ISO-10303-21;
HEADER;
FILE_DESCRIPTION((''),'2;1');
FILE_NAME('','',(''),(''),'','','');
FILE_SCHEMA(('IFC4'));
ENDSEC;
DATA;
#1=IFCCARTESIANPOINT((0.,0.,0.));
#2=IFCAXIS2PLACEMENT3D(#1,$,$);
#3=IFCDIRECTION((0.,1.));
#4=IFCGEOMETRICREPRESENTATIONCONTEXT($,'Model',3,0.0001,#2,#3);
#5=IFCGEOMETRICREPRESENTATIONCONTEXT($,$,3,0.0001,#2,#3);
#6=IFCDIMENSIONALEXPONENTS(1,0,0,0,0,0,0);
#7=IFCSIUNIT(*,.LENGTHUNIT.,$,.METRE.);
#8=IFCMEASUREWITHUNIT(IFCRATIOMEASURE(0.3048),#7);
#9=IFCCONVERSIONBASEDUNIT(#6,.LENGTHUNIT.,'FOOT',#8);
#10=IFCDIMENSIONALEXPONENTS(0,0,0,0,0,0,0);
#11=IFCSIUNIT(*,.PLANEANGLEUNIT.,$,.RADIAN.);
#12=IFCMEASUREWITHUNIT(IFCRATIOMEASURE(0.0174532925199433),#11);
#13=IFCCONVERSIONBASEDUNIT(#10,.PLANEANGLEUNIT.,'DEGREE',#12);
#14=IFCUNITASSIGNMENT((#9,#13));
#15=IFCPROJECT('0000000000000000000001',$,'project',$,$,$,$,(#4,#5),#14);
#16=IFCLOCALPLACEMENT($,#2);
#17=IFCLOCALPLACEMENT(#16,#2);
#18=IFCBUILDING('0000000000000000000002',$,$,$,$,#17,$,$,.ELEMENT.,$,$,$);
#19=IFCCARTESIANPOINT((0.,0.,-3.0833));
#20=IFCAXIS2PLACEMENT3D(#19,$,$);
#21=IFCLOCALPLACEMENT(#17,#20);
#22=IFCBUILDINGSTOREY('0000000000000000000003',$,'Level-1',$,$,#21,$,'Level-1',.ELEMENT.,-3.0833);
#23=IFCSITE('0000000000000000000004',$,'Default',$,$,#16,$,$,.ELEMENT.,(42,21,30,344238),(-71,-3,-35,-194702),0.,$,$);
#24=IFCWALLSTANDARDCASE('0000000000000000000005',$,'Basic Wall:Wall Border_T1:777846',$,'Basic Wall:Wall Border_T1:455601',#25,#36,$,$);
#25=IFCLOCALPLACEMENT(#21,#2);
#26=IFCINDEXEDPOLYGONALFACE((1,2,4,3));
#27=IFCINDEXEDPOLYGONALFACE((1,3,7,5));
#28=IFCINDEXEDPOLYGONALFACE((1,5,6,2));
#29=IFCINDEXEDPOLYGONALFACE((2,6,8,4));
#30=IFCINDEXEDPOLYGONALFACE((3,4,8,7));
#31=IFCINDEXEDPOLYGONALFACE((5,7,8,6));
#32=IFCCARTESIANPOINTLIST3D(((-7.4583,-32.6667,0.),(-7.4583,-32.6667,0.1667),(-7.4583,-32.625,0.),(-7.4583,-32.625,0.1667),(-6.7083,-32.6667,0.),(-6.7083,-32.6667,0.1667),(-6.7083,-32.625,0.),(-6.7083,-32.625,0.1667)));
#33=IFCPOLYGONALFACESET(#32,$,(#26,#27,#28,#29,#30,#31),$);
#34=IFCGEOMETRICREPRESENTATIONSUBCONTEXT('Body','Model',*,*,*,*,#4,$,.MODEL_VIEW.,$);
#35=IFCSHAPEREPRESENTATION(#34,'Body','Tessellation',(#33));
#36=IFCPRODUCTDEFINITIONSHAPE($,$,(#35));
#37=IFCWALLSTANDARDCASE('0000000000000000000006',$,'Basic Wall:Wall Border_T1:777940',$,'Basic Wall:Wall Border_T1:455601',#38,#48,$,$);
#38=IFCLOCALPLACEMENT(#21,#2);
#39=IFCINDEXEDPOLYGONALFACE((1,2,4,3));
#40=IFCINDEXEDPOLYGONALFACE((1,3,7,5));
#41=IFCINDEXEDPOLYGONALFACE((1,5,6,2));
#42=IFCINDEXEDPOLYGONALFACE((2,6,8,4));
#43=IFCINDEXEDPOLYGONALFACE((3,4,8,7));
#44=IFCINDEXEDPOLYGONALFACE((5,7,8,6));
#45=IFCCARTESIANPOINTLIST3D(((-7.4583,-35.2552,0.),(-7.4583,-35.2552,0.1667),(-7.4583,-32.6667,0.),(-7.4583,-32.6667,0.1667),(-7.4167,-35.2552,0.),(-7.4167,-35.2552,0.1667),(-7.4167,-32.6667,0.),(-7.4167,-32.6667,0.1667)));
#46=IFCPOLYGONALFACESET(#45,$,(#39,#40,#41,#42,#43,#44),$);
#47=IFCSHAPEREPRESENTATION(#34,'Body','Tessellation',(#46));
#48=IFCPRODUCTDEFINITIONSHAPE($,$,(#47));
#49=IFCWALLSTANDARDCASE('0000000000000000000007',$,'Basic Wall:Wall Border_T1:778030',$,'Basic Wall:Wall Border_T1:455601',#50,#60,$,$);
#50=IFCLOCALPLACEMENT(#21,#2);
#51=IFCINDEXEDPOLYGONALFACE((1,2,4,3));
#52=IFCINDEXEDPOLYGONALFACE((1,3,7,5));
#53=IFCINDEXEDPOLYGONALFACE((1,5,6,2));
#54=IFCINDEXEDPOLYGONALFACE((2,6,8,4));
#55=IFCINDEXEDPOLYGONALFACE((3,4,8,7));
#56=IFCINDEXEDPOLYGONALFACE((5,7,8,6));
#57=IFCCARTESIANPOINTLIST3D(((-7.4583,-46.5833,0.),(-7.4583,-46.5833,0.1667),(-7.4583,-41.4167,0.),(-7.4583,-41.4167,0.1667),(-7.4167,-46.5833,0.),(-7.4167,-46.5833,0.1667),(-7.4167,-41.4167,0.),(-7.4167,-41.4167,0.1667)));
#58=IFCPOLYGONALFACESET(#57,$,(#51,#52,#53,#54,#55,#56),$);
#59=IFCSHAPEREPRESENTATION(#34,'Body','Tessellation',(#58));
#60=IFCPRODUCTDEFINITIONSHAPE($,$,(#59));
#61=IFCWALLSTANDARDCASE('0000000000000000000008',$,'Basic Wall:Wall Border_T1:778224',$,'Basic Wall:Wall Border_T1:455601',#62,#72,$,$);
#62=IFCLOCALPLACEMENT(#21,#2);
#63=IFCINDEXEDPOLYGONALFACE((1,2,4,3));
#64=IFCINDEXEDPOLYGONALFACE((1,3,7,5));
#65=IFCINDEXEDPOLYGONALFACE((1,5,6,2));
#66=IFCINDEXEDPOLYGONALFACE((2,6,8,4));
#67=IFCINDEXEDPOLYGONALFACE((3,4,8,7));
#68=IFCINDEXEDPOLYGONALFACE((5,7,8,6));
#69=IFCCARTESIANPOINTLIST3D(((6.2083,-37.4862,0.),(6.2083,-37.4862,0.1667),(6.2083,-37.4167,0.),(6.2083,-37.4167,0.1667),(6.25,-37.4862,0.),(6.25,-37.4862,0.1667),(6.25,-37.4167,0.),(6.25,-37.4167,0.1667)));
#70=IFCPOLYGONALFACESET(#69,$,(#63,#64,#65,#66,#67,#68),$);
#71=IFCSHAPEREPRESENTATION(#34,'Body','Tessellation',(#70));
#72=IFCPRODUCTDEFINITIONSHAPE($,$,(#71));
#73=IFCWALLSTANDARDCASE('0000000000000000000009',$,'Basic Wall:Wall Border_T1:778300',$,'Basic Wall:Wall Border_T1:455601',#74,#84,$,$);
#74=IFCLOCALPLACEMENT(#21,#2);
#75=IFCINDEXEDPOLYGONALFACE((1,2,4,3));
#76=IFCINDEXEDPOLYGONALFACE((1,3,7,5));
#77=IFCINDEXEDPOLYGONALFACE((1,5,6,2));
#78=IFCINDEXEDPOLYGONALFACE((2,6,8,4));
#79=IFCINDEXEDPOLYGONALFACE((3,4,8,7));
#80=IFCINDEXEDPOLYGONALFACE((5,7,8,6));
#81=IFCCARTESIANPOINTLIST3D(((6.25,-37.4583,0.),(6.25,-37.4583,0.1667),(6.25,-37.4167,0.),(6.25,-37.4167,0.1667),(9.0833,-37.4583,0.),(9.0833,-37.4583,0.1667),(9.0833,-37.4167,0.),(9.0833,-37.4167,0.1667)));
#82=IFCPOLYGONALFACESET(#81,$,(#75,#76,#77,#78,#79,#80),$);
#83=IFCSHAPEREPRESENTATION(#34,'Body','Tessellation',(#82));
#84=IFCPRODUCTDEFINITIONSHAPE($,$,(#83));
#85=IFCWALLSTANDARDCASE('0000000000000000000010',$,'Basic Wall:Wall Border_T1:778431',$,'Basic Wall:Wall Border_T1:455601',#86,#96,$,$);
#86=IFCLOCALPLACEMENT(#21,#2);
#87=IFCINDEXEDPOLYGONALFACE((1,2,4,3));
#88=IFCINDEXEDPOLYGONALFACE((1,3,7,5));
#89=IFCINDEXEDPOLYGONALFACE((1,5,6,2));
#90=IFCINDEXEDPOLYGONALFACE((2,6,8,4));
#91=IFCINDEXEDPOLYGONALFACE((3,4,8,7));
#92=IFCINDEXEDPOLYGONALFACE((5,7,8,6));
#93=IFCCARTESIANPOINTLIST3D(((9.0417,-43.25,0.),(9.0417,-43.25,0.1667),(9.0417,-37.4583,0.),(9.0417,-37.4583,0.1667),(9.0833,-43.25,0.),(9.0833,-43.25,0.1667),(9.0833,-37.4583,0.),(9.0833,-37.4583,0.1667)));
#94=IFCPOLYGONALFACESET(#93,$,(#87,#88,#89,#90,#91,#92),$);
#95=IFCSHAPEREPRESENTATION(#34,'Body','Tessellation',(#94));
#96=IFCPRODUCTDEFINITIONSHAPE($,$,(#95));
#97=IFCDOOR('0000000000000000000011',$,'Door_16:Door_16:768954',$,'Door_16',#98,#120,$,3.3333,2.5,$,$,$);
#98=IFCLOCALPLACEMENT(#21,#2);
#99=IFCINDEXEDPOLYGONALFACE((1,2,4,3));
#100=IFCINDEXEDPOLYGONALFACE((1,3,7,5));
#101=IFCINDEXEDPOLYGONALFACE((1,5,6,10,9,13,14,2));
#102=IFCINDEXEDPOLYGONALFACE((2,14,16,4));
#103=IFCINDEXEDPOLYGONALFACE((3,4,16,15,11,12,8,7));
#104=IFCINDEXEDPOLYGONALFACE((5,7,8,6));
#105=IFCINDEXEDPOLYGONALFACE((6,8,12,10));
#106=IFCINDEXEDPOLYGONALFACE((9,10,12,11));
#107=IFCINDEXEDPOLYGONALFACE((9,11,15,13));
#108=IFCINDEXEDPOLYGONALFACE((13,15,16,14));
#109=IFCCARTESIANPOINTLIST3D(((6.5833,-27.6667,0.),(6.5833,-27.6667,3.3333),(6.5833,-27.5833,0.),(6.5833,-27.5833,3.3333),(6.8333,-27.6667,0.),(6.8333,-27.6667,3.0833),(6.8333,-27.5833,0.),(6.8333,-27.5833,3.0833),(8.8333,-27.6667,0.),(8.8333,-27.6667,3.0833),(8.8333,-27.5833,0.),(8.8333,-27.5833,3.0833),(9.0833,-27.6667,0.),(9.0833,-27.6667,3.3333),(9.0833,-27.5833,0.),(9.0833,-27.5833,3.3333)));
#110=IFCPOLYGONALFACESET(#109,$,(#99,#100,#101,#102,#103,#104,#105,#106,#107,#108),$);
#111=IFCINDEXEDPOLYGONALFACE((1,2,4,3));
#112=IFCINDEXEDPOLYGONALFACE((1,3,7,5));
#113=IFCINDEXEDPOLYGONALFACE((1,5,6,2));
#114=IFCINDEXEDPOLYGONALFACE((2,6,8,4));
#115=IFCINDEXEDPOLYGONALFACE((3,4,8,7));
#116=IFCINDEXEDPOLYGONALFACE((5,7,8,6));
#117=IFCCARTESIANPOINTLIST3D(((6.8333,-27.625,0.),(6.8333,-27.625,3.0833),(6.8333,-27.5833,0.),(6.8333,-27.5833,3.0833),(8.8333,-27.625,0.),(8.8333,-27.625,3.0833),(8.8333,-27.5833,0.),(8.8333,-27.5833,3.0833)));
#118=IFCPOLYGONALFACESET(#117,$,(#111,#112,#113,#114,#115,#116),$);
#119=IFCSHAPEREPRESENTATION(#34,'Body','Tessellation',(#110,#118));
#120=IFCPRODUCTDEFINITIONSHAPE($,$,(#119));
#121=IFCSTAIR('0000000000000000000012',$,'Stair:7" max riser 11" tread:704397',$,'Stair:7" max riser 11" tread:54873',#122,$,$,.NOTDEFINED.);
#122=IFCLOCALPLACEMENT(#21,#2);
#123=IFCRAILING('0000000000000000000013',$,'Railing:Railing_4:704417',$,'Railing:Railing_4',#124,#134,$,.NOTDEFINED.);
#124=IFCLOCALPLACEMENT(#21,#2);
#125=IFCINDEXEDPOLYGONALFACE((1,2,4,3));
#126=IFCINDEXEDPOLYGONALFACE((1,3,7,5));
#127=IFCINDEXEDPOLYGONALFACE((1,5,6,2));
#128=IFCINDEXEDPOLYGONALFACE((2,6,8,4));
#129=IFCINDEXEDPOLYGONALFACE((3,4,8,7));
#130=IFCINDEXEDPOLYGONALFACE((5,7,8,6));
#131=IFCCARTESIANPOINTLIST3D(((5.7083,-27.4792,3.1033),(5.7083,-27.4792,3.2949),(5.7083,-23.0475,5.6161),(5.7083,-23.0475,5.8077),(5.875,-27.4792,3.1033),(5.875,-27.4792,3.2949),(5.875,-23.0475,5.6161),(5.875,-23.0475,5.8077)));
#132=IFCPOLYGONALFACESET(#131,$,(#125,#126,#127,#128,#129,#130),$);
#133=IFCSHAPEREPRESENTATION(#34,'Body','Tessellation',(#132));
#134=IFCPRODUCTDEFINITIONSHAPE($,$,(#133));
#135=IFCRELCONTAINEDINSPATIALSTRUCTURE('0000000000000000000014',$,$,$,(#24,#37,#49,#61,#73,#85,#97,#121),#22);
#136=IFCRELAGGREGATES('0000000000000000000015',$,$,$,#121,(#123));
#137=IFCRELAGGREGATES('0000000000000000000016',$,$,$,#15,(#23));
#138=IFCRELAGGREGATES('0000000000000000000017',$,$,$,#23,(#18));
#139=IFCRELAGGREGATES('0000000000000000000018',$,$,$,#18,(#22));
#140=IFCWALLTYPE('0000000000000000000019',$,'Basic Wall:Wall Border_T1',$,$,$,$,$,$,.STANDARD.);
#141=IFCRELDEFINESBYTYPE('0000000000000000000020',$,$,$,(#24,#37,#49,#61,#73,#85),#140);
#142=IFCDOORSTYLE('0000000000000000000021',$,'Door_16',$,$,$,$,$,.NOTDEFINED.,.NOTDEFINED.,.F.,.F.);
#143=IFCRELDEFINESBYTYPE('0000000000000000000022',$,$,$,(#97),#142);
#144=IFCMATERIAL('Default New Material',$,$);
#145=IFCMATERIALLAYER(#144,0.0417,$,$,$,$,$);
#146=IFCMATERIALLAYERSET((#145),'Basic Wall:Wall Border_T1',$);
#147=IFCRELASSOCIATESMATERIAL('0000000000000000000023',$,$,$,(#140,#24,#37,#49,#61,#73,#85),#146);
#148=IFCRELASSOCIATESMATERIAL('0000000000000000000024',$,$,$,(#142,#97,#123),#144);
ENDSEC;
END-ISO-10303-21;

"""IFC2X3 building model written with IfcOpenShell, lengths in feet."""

from ifc_helpers import new_model, entity, si_unit, converted_unit, direction, frame, frame_2d, origin, place, context, subcontext, project, spatial, polyline, rectangle, outline, extrude, source, transform, mapped, material, layer, layer_set, layer_usage, type_object, type_shapes, element, aggregate, save


model = new_model("IFC2X3")

# Units and contexts
model_context = context("Model", 3, precision=0.0001, world=origin(), true_north=direction((0.0, 1.0)))
context_of_model = context(None, 3, precision=0.0001, world=origin(), true_north=direction((0.0, 1.0)))
body_context = subcontext(model_context, "Body", "Model", "MODEL_VIEW")
ifc_project = project(units=[converted_unit("LENGTHUNIT", "FOOT", entity("IfcRatioMeasure", 0.3048), si_unit("LENGTHUNIT", "METRE"), dimensions=[1, 0, 0, 0, 0, 0, 0]), converted_unit("PLANEANGLEUNIT", "DEGREE", entity("IfcRatioMeasure", 0.0174532925199433), si_unit("PLANEANGLEUNIT", "RADIAN"), dimensions=[0, 0, 0, 0, 0, 0, 0])], contexts=[model_context, context_of_model])

# Site, building, storey
site_placement = place(None, origin())
site = spatial("IfcSite", under=ifc_project, at=site_placement, Name="Default", CompositionType="ELEMENT", RefLatitude=(42, 21, 30, 344238), RefLongitude=(-71, -3, -35, -194702), RefElevation=0.0)
building_placement = place(site_placement, origin())
building = spatial("IfcBuilding", under=site, at=building_placement, CompositionType="ELEMENT")
storey_placement = place(building_placement, frame((0.0, 0.0, -3.0833)))
storey = spatial("IfcBuildingStorey", under=building, at=storey_placement, Name="Level-1", LongName="Level-1", CompositionType="ELEMENT", Elevation=-3.0833)

# Shared definitions
ifc_material_1 = material(Name="Default New Material")

# Walls
ifc_layer_1 = layer(ifc_material_1, 0.0417)
ifc_layer_set_1 = layer_set([ifc_layer_1], Name="Basic Wall:Wall Border_T1")
wall_type_1 = type_object("IfcWallType", Name="Basic Wall:Wall Border_T1", PredefinedType="STANDARD", material=ifc_layer_set_1)
ifc_layer_usage_1 = layer_usage(ifc_layer_set_1, "AXIS2", "NEGATIVE", 0.0208)
wall_1_placement = place(storey_placement, frame((-6.7083, -32.6458, 0.0), z_axis=(0.0, 0.0, 1.0), x_axis=(-1.0, 0.0, 0.0)))
element("IfcWallStandardCase", 1, at=wall_1_placement, inside=storey, type_object=wall_type_1, material=ifc_layer_usage_1, Name="Basic Wall:Wall Border_T1:777846", ObjectType="Basic Wall:Wall Border_T1:455601", context=body_context, shape_type="SweptSolid", body=[
    extrude(rectangle(XDim=0.75, YDim=0.0417, at=frame_2d((0.375, 0.0), x_axis=(-1.0, 0.0))), origin(), (0.0, 0.0, 1.0), 0.1667),
])
ifc_layer_usage_2 = layer_usage(ifc_layer_set_1, "AXIS2", "NEGATIVE", 0.0208)
wall_2_placement = place(storey_placement, frame((-7.4375, -32.6667, 0.0), z_axis=(0.0, 0.0, 1.0), x_axis=(0.0, -1.0, 0.0)))
element("IfcWallStandardCase", 2, at=wall_2_placement, inside=storey, type_object=wall_type_1, material=ifc_layer_usage_2, Name="Basic Wall:Wall Border_T1:777940", ObjectType="Basic Wall:Wall Border_T1:455601", context=body_context, shape_type="SweptSolid", body=[
    extrude(rectangle(XDim=2.5886, YDim=0.0417, at=frame_2d((1.2943, 0.0), x_axis=(-1.0, 0.0))), origin(), (0.0, 0.0, 1.0), 0.1667),
])
ifc_layer_usage_3 = layer_usage(ifc_layer_set_1, "AXIS2", "NEGATIVE", 0.0208)
wall_3_placement = place(storey_placement, frame((-7.4375, -41.4167, 0.0), z_axis=(0.0, 0.0, 1.0), x_axis=(0.0, -1.0, 0.0)))
element("IfcWallStandardCase", 3, at=wall_3_placement, inside=storey, type_object=wall_type_1, material=ifc_layer_usage_3, Name="Basic Wall:Wall Border_T1:778030", ObjectType="Basic Wall:Wall Border_T1:455601", context=body_context, shape_type="SweptSolid", body=[
    extrude(rectangle(XDim=5.1667, YDim=0.0417, at=frame_2d((2.5833, 0.0), x_axis=(-1.0, 0.0))), origin(), (0.0, 0.0, 1.0), 0.1667),
])
ifc_layer_usage_4 = layer_usage(ifc_layer_set_1, "AXIS2", "POSITIVE", -0.0208)
wall_4_placement = place(storey_placement, frame((6.2292, -37.4862, 0.0), z_axis=(0.0, 0.0, 1.0), x_axis=(0.0, 1.0, 0.0)))
element("IfcWallStandardCase", 4, at=wall_4_placement, inside=storey, type_object=wall_type_1, material=ifc_layer_usage_4, Name="Basic Wall:Wall Border_T1:778224", ObjectType="Basic Wall:Wall Border_T1:455601", context=body_context, shape_type="SweptSolid", body=[
    extrude(rectangle(XDim=0.0696, YDim=0.0417, at=frame_2d((0.0348, 0.0), x_axis=(-1.0, 0.0))), origin(), (0.0, 0.0, 1.0), 0.1667),
])
ifc_layer_usage_5 = layer_usage(ifc_layer_set_1, "AXIS2", "POSITIVE", -0.0208)
wall_5_placement = place(storey_placement, frame((6.25, -37.4375, 0.0)))
element("IfcWallStandardCase", 5, at=wall_5_placement, inside=storey, type_object=wall_type_1, material=ifc_layer_usage_5, Name="Basic Wall:Wall Border_T1:778300", ObjectType="Basic Wall:Wall Border_T1:455601", context=body_context, shape_type="SweptSolid", body=[
    extrude(rectangle(XDim=2.8333, YDim=0.0417, at=frame_2d((1.4167, 0.0), x_axis=(-1.0, 0.0))), origin(), (0.0, 0.0, 1.0), 0.1667),
])
ifc_layer_usage_6 = layer_usage(ifc_layer_set_1, "AXIS2", "POSITIVE", -0.0208)
wall_6_placement = place(storey_placement, frame((9.0625, -37.4583, 0.0), z_axis=(0.0, 0.0, 1.0), x_axis=(0.0, -1.0, 0.0)))
element("IfcWallStandardCase", 6, at=wall_6_placement, inside=storey, type_object=wall_type_1, material=ifc_layer_usage_6, Name="Basic Wall:Wall Border_T1:778431", ObjectType="Basic Wall:Wall Border_T1:455601", context=body_context, shape_type="SweptSolid", body=[
    extrude(rectangle(XDim=5.7917, YDim=0.0417, at=frame_2d((2.8958, 0.0), x_axis=(-1.0, 0.0))), origin(), (0.0, 0.0, 1.0), 0.1667),
])

# Door
door_style_1 = type_object("IfcDoorStyle", Name="Door_16", ConstructionType="NOTDEFINED", OperationType="NOTDEFINED", ParameterTakesPrecedence=False, Sizeable=False, material=ifc_material_1)
shared_shape_1 = source(origin(), body_context, "Body", "SweptSolid", [
    extrude(outline(polyline([(-1.4792, 1.0), (1.6042, 1.0), (1.6042, 1.25), (-1.7292, 1.25), (-1.7292, -1.25), (1.6042, -1.25), (1.6042, -1.0), (-1.4792, -1.0), (-1.4792, 1.0)])), frame((7.8333, -27.6667, -1.4792), z_axis=(0.0, 1.0, 0.0), x_axis=(0.0, 0.0, -1.0)), (0.0, 0.0, 1.0), 0.0833),
    extrude(rectangle(XDim=0.0417, YDim=2.0, at=frame_2d((0.0, 0.0), x_axis=(1.0, 0.0))), frame((7.8333, -27.6042, -3.0833), z_axis=(0.0, 0.0, 1.0), x_axis=(0.0, 1.0, 0.0)), (0.0, 0.0, 1.0), 3.0833),
])
type_shapes(door_style_1, [shared_shape_1])
door_1_placement = place(storey_placement, frame((0.0, 0.0, 3.0833)))
element("IfcDoor", 7, at=door_1_placement, inside=storey, type_object=door_style_1, material=ifc_material_1, Name="Door_16:Door_16:768954", ObjectType="Door_16", OverallHeight=3.3333, OverallWidth=2.5, context=body_context, shape_type="MappedRepresentation", body=[
    mapped(shared_shape_1, transform((0.0, 0.0, 0.0), scale=1.0)),
])

# Stair, railing
stair_placement = place(storey_placement, origin())
stair = element("IfcStair", 8, at=stair_placement, inside=storey, Name="Stair:7\" max riser 11\" tread:704397", ObjectType="Stair:7\" max riser 11\" tread:54873", ShapeType="NOTDEFINED")
railing_placement = place(stair_placement, frame((5.7083, -27.4792, 3.1033)))
railing = element("IfcRailing", 9, at=railing_placement, material=ifc_material_1, Name="Railing:Railing_4:704417", ObjectType="Railing:Railing_4", PredefinedType="NOTDEFINED", context=body_context, shape_type="SweptSolid", body=[
    extrude(outline(polyline([(-2.5945, -0.0833), (2.5, -0.0833), (2.5945, 0.0833), (-2.5, 0.0833), (-2.5945, -0.0833)])), frame((0.0, 2.2158, 1.3522), z_axis=(1.0, 0.0, 0.0), x_axis=(0.0, 0.869893, 0.493241)), (0.0, 0.0, 1.0), 0.1667),
])
aggregate(stair, [railing])

save(model, "model.ifc")
